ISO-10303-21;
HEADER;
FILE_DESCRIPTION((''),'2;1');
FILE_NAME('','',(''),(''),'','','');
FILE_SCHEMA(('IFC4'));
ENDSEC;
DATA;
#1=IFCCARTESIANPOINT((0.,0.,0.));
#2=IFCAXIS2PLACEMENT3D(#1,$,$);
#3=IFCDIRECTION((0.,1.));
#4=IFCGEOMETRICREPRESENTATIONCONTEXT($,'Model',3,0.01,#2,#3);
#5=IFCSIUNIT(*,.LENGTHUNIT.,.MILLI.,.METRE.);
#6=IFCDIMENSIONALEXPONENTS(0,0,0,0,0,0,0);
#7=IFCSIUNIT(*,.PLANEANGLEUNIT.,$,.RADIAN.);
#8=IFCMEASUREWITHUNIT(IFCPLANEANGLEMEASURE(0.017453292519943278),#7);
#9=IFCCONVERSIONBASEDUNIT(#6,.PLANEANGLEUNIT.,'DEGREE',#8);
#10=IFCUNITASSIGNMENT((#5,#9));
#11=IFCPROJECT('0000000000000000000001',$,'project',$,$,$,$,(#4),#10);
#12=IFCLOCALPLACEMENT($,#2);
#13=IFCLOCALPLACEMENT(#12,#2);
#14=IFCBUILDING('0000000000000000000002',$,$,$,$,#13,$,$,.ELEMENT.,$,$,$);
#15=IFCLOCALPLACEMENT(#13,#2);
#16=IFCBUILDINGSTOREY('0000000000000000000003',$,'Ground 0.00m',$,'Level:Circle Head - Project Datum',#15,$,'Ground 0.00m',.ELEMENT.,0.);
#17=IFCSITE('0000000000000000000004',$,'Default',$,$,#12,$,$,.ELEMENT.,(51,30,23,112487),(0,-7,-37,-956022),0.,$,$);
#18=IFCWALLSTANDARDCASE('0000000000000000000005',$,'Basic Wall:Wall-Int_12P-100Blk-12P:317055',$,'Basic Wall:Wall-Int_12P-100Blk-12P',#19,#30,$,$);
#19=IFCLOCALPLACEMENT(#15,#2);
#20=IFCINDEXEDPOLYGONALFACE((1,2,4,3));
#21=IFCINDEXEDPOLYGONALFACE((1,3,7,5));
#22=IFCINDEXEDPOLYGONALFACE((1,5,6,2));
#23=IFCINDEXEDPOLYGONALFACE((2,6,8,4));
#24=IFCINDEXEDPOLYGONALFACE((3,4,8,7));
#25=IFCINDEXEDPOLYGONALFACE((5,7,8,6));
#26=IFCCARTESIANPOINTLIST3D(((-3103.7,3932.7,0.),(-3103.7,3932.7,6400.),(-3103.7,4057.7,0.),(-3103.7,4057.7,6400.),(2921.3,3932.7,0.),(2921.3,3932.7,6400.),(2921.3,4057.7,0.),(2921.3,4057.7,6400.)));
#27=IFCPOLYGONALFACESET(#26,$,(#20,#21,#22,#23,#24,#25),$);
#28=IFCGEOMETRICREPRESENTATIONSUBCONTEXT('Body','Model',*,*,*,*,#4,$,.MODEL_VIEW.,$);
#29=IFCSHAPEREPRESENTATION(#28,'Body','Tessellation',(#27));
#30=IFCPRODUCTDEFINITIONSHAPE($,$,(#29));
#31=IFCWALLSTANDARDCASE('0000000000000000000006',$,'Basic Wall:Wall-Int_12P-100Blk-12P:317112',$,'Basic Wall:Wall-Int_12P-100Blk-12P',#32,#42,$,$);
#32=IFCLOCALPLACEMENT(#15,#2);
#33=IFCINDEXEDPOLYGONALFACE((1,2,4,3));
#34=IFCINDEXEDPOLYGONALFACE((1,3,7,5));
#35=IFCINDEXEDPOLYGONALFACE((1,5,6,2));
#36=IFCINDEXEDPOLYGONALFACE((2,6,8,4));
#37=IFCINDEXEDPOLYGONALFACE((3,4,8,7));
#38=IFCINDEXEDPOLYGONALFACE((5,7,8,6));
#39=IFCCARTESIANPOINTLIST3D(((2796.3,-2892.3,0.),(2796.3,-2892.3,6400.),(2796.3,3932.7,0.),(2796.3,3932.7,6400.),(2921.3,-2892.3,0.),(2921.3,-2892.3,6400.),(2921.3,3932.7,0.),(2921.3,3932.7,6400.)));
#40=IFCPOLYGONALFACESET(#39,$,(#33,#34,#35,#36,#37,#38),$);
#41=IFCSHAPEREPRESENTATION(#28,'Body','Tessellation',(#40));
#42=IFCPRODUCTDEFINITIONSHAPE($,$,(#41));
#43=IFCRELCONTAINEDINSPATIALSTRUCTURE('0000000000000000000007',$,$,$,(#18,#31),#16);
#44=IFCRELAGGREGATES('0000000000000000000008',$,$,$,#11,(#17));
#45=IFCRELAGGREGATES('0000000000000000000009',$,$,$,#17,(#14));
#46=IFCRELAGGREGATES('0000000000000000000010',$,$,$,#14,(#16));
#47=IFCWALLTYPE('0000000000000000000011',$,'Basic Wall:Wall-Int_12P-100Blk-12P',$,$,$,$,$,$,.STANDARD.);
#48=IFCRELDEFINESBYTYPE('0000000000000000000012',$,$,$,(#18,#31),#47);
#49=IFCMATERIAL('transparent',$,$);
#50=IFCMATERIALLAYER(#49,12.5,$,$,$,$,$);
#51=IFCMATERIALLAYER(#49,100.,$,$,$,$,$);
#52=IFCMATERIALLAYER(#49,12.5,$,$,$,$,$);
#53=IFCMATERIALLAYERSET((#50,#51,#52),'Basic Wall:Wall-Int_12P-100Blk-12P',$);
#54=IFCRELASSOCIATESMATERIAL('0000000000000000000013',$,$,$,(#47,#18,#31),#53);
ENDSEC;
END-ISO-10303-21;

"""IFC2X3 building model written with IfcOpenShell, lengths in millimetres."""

from ifc_helpers import new_model, entity, si_unit, converted_unit, direction, frame, frame_2d, origin, place, context, subcontext, project, spatial, rectangle, extrude, material, layer, layer_set, layer_usage, type_object, element, save


model = new_model("IFC2X3")

# Units and contexts
model_context = context("Model", 3, precision=0.01, world=origin(), true_north=direction((0.0, 1.0)))
body_context = subcontext(model_context, "Body", "Model", "MODEL_VIEW")
ifc_project = project(units=[si_unit("LENGTHUNIT", "METRE", prefix="MILLI"), converted_unit("PLANEANGLEUNIT", "DEGREE", entity("IfcPlaneAngleMeasure", 0.017453292519943278), si_unit("PLANEANGLEUNIT", "RADIAN"), dimensions=[0, 0, 0, 0, 0, 0, 0])], contexts=[model_context])

# Site, building, storey
site_placement = place(None, origin())
site = spatial("IfcSite", under=ifc_project, at=site_placement, Name="Default", CompositionType="ELEMENT", RefLatitude=(51, 30, 23, 112487), RefLongitude=(0, -7, -37, -956022), RefElevation=0.0)
building_placement = place(site_placement, origin())
building = spatial("IfcBuilding", under=site, at=building_placement, CompositionType="ELEMENT")
storey_placement = place(building_placement, origin())
storey = spatial("IfcBuildingStorey", under=building, at=storey_placement, Name="Ground 0.00m", ObjectType="Level:Circle Head - Project Datum", LongName="Ground 0.00m", CompositionType="ELEMENT", Elevation=0.0)

# Walls
ifc_material_1 = material(Name="transparent")
ifc_layer_1 = layer(ifc_material_1, 12.5)
ifc_layer_2 = layer(ifc_material_1, 100.0)
ifc_layer_3 = layer(ifc_material_1, 12.5)
ifc_layer_set = layer_set([ifc_layer_1, ifc_layer_2, ifc_layer_3], Name="Basic Wall:Wall-Int_12P-100Blk-12P")
ifc_layer_usage_1 = layer_usage(ifc_layer_set, "AXIS2", "NEGATIVE", 62.5)
wall_type = type_object("IfcWallType", Name="Basic Wall:Wall-Int_12P-100Blk-12P", PredefinedType="STANDARD", material=ifc_layer_set)
wall_1_placement = place(storey_placement, frame((-3103.7, 3995.2, 0.0)))
element("IfcWallStandardCase", 1, at=wall_1_placement, inside=storey, type_object=wall_type, material=ifc_layer_usage_1, Name="Basic Wall:Wall-Int_12P-100Blk-12P:317055", ObjectType="Basic Wall:Wall-Int_12P-100Blk-12P", context=body_context, shape_type="SweptSolid", body=[
    extrude(rectangle(XDim=6025.0, YDim=125.0, at=frame_2d((3012.5, 0.0), x_axis=(-1.0, 0.0))), origin(), (0.0, 0.0, 1.0), 6400.0),
])
ifc_layer_usage_2 = layer_usage(ifc_layer_set, "AXIS2", "NEGATIVE", 62.5)
wall_2_placement = place(storey_placement, frame((2858.8, 3932.7, 0.0), z_axis=(0.0, 0.0, 1.0), x_axis=(0.0, -1.0, 0.0)))
element("IfcWallStandardCase", 2, at=wall_2_placement, inside=storey, type_object=wall_type, material=ifc_layer_usage_2, Name="Basic Wall:Wall-Int_12P-100Blk-12P:317112", ObjectType="Basic Wall:Wall-Int_12P-100Blk-12P", context=body_context, shape_type="SweptSolid", body=[
    extrude(rectangle(XDim=6825.0, YDim=125.0, at=frame_2d((3412.5, 0.0), x_axis=(-1.0, 0.0))), origin(), (0.0, 0.0, 1.0), 6400.0),
])

save(model, "model.ifc")
